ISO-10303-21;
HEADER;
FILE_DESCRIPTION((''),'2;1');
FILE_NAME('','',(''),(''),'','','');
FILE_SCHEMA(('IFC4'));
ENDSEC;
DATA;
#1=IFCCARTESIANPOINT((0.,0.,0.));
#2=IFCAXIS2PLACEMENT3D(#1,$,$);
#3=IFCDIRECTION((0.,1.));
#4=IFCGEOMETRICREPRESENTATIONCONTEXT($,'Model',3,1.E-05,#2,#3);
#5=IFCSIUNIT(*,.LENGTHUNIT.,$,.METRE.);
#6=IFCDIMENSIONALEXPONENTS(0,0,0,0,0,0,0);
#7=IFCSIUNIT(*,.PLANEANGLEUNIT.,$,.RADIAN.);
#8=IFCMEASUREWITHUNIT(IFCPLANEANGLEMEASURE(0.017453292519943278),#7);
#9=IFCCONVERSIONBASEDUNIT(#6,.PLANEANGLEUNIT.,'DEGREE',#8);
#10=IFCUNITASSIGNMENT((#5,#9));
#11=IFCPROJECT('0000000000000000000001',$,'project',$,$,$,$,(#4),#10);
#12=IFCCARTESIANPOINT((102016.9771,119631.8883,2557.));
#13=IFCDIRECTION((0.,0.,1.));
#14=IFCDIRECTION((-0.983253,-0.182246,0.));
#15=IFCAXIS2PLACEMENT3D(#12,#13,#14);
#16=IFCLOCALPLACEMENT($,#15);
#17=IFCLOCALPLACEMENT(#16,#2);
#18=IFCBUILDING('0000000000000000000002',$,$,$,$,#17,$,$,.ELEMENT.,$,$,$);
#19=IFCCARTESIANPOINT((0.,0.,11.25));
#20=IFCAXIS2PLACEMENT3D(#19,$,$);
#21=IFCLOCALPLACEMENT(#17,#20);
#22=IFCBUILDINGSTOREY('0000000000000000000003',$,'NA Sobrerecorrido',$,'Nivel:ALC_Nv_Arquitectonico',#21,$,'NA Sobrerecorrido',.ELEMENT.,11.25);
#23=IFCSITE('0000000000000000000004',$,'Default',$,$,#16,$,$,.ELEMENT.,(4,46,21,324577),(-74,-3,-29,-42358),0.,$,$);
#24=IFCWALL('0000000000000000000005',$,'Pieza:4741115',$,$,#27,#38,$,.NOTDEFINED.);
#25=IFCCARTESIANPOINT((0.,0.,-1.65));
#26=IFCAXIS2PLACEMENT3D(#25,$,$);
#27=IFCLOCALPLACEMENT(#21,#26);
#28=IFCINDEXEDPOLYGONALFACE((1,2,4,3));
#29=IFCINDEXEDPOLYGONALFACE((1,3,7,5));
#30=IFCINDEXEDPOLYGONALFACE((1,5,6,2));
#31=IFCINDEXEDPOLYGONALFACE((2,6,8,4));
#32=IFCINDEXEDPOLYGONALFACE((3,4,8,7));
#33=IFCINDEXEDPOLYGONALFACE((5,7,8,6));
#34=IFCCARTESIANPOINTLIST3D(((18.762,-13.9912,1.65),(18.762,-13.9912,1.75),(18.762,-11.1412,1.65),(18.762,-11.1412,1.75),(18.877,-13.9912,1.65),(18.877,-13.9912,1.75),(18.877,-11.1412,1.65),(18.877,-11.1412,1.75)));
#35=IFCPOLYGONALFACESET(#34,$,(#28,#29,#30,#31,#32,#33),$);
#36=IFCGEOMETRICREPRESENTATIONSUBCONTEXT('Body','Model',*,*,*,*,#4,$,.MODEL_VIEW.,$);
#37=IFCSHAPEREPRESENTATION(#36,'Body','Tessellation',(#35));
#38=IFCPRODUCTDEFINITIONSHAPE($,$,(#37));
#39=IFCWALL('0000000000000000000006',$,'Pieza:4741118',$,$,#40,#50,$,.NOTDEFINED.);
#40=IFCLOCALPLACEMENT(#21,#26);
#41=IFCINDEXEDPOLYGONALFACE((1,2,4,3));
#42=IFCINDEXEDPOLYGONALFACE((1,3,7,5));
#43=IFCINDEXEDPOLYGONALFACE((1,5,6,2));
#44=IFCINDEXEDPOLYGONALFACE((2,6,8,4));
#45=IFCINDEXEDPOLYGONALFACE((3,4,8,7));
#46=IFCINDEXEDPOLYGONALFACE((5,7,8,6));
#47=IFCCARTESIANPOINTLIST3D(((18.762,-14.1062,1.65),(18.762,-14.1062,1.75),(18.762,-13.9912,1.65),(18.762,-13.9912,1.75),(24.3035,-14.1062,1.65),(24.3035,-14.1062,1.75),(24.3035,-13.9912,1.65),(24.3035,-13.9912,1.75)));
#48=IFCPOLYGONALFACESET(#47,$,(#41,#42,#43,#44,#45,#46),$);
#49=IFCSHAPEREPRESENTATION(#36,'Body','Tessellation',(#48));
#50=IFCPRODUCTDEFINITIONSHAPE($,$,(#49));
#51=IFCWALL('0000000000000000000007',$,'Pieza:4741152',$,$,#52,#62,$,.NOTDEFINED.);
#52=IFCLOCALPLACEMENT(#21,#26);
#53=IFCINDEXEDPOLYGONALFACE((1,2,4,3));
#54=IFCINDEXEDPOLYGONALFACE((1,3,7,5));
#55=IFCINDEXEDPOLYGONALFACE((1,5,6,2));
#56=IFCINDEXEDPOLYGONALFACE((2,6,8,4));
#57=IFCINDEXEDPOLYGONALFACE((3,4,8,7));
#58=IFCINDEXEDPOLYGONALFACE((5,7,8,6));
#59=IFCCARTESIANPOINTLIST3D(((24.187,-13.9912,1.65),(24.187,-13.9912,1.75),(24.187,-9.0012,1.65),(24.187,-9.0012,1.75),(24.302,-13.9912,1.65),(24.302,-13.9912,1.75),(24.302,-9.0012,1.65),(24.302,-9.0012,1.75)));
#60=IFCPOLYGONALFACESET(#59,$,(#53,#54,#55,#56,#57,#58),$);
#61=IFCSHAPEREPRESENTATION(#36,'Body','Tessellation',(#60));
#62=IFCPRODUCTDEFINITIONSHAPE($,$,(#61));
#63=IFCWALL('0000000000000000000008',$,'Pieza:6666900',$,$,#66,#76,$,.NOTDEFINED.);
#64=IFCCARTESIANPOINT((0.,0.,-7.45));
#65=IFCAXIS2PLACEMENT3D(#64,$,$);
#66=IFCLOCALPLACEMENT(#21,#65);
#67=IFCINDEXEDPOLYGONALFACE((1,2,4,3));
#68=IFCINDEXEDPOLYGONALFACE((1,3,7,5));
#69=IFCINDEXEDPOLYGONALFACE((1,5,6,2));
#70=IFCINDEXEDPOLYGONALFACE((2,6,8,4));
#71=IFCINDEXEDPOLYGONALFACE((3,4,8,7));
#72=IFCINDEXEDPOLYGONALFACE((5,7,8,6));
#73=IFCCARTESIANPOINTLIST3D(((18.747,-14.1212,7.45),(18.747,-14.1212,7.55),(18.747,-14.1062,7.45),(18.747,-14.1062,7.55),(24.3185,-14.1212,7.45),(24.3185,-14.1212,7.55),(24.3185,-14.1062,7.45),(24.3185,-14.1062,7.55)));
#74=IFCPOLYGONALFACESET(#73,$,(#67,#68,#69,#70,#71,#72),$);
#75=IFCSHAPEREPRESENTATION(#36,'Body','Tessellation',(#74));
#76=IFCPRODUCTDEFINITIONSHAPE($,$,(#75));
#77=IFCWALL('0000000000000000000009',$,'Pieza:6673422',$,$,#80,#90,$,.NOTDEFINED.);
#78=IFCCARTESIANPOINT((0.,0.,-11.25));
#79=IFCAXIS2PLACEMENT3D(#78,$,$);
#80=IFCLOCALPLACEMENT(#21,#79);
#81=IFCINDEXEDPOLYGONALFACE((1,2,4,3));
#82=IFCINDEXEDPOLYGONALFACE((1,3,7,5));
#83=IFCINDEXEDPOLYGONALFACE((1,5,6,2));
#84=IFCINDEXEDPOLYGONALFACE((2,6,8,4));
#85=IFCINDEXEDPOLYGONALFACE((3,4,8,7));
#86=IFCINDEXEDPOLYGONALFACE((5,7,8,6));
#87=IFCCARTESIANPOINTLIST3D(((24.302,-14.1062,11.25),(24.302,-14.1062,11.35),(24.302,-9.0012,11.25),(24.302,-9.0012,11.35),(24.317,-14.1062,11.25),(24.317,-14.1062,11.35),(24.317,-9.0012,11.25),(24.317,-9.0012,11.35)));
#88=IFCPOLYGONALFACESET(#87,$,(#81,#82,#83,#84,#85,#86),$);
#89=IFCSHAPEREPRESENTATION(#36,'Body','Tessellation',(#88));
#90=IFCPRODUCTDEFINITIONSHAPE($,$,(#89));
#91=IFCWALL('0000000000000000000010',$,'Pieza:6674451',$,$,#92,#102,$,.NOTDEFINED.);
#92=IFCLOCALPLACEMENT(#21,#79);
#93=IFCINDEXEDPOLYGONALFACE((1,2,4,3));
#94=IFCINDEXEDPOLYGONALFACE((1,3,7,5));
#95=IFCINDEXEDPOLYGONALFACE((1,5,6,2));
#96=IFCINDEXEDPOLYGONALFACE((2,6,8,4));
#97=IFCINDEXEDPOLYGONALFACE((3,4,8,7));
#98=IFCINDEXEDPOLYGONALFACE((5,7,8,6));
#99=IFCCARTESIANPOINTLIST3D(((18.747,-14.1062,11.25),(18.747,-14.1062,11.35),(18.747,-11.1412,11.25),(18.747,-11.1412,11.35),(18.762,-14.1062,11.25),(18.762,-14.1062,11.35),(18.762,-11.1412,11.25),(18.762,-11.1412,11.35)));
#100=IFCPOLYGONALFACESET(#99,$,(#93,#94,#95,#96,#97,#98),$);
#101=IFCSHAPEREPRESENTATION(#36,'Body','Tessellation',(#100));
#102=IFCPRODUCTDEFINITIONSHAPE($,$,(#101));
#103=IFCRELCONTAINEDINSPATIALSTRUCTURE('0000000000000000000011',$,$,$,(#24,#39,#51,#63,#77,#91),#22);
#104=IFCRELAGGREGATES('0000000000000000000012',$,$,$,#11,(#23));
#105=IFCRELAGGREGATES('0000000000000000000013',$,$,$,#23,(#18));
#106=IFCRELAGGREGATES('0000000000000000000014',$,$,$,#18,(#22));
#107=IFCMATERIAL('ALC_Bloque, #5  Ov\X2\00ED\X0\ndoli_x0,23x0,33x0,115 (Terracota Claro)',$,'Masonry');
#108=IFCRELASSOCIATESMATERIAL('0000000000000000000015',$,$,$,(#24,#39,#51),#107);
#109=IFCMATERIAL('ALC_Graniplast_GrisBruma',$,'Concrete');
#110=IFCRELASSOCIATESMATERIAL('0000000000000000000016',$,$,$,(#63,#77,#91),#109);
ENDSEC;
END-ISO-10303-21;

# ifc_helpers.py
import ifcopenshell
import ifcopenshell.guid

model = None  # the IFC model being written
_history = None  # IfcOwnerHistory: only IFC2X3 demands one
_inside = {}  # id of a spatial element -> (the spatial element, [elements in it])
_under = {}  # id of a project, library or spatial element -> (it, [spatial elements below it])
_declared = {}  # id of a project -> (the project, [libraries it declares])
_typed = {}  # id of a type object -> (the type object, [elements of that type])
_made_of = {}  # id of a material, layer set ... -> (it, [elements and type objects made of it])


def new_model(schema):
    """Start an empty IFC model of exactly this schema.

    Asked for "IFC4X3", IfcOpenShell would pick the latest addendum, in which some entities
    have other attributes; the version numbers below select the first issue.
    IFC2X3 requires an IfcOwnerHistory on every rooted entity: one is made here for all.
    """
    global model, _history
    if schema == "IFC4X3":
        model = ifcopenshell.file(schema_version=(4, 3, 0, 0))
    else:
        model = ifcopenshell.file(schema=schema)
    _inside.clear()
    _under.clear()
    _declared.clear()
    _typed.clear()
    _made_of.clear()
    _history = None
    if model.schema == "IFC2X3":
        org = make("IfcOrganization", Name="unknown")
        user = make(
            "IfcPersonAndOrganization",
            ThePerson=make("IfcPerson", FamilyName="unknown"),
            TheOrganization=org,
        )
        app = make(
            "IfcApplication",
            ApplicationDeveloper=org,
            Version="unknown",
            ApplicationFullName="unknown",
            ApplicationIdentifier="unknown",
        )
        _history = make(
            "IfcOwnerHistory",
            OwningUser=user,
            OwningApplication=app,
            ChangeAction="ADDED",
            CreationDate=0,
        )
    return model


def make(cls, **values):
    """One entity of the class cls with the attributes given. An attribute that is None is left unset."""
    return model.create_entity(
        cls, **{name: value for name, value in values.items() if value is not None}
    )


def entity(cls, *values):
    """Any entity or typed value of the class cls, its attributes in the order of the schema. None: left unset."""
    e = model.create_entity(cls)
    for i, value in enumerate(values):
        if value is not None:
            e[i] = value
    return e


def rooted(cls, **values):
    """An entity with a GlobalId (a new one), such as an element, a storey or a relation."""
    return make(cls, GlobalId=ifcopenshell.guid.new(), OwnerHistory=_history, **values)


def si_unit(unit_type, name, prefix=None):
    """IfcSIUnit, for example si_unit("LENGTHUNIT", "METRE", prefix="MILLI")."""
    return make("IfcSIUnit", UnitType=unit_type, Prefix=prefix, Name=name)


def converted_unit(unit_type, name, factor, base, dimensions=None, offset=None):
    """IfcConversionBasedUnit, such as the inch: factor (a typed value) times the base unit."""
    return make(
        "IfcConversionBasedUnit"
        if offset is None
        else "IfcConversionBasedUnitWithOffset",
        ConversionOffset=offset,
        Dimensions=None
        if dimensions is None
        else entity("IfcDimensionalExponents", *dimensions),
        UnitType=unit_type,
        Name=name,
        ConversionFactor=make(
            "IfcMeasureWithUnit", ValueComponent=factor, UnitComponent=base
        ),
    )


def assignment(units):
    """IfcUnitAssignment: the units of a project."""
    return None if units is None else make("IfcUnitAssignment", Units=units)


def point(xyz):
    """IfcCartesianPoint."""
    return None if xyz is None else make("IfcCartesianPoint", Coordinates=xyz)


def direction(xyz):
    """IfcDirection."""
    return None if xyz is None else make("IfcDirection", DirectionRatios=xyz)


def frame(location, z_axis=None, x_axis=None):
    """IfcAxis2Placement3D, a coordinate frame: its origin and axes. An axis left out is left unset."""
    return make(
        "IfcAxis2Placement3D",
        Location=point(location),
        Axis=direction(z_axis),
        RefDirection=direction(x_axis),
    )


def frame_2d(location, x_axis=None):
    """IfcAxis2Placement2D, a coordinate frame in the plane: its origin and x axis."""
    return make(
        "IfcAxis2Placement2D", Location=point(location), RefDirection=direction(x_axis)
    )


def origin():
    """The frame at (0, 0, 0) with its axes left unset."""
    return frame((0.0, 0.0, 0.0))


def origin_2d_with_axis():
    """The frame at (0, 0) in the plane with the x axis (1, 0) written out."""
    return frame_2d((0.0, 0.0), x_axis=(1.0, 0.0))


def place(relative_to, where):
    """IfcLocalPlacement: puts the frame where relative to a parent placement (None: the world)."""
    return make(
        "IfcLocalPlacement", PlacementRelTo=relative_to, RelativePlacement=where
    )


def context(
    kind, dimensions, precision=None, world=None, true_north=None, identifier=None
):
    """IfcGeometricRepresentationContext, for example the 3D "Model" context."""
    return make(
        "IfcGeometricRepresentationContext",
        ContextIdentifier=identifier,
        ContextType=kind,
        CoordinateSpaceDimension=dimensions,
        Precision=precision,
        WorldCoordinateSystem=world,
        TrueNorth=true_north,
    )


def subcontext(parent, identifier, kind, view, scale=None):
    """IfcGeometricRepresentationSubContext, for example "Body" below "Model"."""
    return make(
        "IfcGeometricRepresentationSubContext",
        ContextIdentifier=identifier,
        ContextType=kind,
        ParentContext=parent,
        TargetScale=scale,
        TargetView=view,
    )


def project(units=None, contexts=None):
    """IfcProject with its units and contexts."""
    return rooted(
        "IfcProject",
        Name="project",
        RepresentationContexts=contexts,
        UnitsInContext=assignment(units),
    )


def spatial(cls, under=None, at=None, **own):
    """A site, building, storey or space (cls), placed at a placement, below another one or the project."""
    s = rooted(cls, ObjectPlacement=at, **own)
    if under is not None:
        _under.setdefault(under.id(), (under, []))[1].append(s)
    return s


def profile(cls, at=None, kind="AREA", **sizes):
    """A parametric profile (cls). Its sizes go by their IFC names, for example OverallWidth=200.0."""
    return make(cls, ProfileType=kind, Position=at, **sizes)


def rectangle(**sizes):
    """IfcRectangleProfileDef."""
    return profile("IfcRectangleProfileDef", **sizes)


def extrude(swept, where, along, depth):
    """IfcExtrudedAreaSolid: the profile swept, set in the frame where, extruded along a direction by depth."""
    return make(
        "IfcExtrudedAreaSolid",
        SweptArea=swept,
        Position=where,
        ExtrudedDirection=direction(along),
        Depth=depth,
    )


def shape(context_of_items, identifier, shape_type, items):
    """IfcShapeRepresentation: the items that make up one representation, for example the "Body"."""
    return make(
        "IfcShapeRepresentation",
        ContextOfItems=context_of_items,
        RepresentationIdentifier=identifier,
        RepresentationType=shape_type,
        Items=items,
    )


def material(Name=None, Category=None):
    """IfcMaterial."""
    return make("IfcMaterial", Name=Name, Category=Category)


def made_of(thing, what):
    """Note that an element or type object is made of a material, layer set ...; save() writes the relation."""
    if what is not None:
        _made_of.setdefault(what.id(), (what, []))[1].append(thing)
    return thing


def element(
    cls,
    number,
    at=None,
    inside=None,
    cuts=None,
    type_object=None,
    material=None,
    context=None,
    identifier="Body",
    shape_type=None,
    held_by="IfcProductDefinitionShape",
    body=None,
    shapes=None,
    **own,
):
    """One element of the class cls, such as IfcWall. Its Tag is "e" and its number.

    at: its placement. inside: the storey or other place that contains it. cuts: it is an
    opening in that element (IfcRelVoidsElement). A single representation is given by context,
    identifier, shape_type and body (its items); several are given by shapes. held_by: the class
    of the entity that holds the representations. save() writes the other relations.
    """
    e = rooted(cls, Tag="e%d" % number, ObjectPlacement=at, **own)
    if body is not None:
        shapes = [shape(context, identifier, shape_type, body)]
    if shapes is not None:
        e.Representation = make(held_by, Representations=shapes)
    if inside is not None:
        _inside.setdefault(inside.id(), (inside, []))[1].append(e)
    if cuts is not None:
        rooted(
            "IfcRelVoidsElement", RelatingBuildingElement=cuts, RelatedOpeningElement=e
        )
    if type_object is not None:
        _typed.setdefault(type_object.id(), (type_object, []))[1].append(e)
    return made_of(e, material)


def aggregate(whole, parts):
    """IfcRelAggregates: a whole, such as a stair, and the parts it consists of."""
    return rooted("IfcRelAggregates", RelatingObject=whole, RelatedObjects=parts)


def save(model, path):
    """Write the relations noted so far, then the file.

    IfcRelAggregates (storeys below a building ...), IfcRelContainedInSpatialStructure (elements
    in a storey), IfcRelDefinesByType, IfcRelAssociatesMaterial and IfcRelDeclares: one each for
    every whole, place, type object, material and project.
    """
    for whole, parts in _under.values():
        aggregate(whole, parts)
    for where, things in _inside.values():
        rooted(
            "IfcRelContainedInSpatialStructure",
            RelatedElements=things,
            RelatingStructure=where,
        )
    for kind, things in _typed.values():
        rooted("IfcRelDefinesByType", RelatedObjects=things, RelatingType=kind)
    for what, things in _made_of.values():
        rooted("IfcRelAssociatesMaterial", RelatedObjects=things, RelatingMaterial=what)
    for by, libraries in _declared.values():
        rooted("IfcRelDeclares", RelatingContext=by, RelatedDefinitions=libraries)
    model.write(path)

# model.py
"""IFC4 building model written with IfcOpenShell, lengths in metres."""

from ifc_helpers import new_model, entity, si_unit, converted_unit, direction, frame, frame_2d, origin, origin_2d_with_axis, place, context, subcontext, project, spatial, rectangle, extrude, material, element, save


model = new_model("IFC4")

# Units and contexts
model_context = context("Model", 3, precision=1e-05, world=origin(), true_north=direction((0.0, 1.0)))
body_context = subcontext(model_context, "Body", "Model", "MODEL_VIEW")
ifc_project = project(units=[si_unit("LENGTHUNIT", "METRE"), converted_unit("PLANEANGLEUNIT", "DEGREE", entity("IfcPlaneAngleMeasure", 0.017453292519943278), si_unit("PLANEANGLEUNIT", "RADIAN"), dimensions=[0, 0, 0, 0, 0, 0, 0])], contexts=[model_context])

# Site, building, storey
site_placement = place(None, frame((102016.9771, 119631.8883, 2557.0), z_axis=(0.0, 0.0, 1.0), x_axis=(-0.983253, -0.182246, 0.0)))
site = spatial("IfcSite", under=ifc_project, at=site_placement, Name="Default", CompositionType="ELEMENT", RefLatitude=(4, 46, 21, 324577), RefLongitude=(-74, -3, -29, -42358), RefElevation=0.0)
building_placement = place(site_placement, origin())
building = spatial("IfcBuilding", under=site, at=building_placement, CompositionType="ELEMENT")
storey_placement = place(building_placement, frame((0.0, 0.0, 11.25)))
storey = spatial("IfcBuildingStorey", under=building, at=storey_placement, Name="NA Sobrerecorrido", ObjectType="Nivel:ALC_Nv_Arquitectonico", LongName="NA Sobrerecorrido", CompositionType="ELEMENT", Elevation=11.25)

# Walls
ifc_material_1 = material(Name="ALC_Bloque, #5  Ovíndoli_x0,23x0,33x0,115 (Terracota Claro)", Category="Masonry")
wall_1_placement = place(storey_placement, frame((0.0, 0.0, -1.65)))
element("IfcWall", 1, at=wall_1_placement, inside=storey, material=ifc_material_1, Name="Pieza:4741115", PredefinedType="NOTDEFINED", context=body_context, shape_type="SweptSolid", body=[
    extrude(rectangle(XDim=2.85, YDim=0.115, at=frame_2d((0.0, 0.0), x_axis=(1.0, 0.0))), frame((18.8195, -12.5662, 1.65), z_axis=(0.0, 0.0, 1.0), x_axis=(0.0, -1.0, 0.0)), (0.0, 0.0, 1.0), 0.1),
])
wall_2_placement = place(storey_placement, frame((0.0, 0.0, -1.65)))
element("IfcWall", 2, at=wall_2_placement, inside=storey, material=ifc_material_1, Name="Pieza:4741118", PredefinedType="NOTDEFINED", context=body_context, shape_type="SweptSolid", body=[
    extrude(rectangle(XDim=0.115, YDim=5.5415, at=frame_2d((0.0, 0.0), x_axis=(1.0, 0.0))), frame((21.5328, -14.0487, 1.65), z_axis=(0.0, 0.0, 1.0), x_axis=(0.0, -1.0, 0.0)), (0.0, 0.0, 1.0), 0.1),
])
wall_3_placement = place(storey_placement, frame((0.0, 0.0, -1.65)))
element("IfcWall", 3, at=wall_3_placement, inside=storey, material=ifc_material_1, Name="Pieza:4741152", PredefinedType="NOTDEFINED", context=body_context, shape_type="SweptSolid", body=[
    extrude(rectangle(XDim=4.99, YDim=0.115, at=frame_2d((0.0, 0.0), x_axis=(1.0, 0.0))), frame((24.2445, -11.4962, 1.65), z_axis=(0.0, 0.0, 1.0), x_axis=(0.0, -1.0, 0.0)), (0.0, 0.0, 1.0), 0.1),
])
ifc_material_2 = material(Name="ALC_Graniplast_GrisBruma", Category="Concrete")
wall_4_placement = place(storey_placement, frame((0.0, 0.0, -7.45)))
element("IfcWall", 4, at=wall_4_placement, inside=storey, material=ifc_material_2, Name="Pieza:6666900", PredefinedType="NOTDEFINED", context=body_context, shape_type="SweptSolid", body=[
    extrude(rectangle(XDim=0.015, YDim=5.5715, at=origin_2d_with_axis()), frame((21.5328, -14.1137, 7.45), z_axis=(0.0, 0.0, 1.0), x_axis=(0.0, -1.0, 0.0)), (0.0, 0.0, 1.0), 0.1),
])
wall_5_placement = place(storey_placement, frame((0.0, 0.0, -11.25)))
element("IfcWall", 5, at=wall_5_placement, inside=storey, material=ifc_material_2, Name="Pieza:6673422", PredefinedType="NOTDEFINED", context=body_context, shape_type="SweptSolid", body=[
    extrude(rectangle(XDim=5.105, YDim=0.015, at=frame_2d((0.0, 0.0), x_axis=(1.0, 0.0))), frame((24.3095, -11.5537, 11.25), z_axis=(0.0, 0.0, 1.0), x_axis=(0.0, -1.0, 0.0)), (0.0, 0.0, 1.0), 0.1),
])
wall_6_placement = place(storey_placement, frame((0.0, 0.0, -11.25)))
element("IfcWall", 6, at=wall_6_placement, inside=storey, material=ifc_material_2, Name="Pieza:6674451", PredefinedType="NOTDEFINED", context=body_context, shape_type="SweptSolid", body=[
    extrude(rectangle(XDim=2.965, YDim=0.015, at=frame_2d((0.0, 0.0), x_axis=(1.0, 0.0))), frame((18.7545, -12.6237, 11.25), z_axis=(0.0, 0.0, 1.0), x_axis=(0.0, -1.0, 0.0)), (0.0, 0.0, 1.0), 0.1),
])

save(model, "model.ifc")
